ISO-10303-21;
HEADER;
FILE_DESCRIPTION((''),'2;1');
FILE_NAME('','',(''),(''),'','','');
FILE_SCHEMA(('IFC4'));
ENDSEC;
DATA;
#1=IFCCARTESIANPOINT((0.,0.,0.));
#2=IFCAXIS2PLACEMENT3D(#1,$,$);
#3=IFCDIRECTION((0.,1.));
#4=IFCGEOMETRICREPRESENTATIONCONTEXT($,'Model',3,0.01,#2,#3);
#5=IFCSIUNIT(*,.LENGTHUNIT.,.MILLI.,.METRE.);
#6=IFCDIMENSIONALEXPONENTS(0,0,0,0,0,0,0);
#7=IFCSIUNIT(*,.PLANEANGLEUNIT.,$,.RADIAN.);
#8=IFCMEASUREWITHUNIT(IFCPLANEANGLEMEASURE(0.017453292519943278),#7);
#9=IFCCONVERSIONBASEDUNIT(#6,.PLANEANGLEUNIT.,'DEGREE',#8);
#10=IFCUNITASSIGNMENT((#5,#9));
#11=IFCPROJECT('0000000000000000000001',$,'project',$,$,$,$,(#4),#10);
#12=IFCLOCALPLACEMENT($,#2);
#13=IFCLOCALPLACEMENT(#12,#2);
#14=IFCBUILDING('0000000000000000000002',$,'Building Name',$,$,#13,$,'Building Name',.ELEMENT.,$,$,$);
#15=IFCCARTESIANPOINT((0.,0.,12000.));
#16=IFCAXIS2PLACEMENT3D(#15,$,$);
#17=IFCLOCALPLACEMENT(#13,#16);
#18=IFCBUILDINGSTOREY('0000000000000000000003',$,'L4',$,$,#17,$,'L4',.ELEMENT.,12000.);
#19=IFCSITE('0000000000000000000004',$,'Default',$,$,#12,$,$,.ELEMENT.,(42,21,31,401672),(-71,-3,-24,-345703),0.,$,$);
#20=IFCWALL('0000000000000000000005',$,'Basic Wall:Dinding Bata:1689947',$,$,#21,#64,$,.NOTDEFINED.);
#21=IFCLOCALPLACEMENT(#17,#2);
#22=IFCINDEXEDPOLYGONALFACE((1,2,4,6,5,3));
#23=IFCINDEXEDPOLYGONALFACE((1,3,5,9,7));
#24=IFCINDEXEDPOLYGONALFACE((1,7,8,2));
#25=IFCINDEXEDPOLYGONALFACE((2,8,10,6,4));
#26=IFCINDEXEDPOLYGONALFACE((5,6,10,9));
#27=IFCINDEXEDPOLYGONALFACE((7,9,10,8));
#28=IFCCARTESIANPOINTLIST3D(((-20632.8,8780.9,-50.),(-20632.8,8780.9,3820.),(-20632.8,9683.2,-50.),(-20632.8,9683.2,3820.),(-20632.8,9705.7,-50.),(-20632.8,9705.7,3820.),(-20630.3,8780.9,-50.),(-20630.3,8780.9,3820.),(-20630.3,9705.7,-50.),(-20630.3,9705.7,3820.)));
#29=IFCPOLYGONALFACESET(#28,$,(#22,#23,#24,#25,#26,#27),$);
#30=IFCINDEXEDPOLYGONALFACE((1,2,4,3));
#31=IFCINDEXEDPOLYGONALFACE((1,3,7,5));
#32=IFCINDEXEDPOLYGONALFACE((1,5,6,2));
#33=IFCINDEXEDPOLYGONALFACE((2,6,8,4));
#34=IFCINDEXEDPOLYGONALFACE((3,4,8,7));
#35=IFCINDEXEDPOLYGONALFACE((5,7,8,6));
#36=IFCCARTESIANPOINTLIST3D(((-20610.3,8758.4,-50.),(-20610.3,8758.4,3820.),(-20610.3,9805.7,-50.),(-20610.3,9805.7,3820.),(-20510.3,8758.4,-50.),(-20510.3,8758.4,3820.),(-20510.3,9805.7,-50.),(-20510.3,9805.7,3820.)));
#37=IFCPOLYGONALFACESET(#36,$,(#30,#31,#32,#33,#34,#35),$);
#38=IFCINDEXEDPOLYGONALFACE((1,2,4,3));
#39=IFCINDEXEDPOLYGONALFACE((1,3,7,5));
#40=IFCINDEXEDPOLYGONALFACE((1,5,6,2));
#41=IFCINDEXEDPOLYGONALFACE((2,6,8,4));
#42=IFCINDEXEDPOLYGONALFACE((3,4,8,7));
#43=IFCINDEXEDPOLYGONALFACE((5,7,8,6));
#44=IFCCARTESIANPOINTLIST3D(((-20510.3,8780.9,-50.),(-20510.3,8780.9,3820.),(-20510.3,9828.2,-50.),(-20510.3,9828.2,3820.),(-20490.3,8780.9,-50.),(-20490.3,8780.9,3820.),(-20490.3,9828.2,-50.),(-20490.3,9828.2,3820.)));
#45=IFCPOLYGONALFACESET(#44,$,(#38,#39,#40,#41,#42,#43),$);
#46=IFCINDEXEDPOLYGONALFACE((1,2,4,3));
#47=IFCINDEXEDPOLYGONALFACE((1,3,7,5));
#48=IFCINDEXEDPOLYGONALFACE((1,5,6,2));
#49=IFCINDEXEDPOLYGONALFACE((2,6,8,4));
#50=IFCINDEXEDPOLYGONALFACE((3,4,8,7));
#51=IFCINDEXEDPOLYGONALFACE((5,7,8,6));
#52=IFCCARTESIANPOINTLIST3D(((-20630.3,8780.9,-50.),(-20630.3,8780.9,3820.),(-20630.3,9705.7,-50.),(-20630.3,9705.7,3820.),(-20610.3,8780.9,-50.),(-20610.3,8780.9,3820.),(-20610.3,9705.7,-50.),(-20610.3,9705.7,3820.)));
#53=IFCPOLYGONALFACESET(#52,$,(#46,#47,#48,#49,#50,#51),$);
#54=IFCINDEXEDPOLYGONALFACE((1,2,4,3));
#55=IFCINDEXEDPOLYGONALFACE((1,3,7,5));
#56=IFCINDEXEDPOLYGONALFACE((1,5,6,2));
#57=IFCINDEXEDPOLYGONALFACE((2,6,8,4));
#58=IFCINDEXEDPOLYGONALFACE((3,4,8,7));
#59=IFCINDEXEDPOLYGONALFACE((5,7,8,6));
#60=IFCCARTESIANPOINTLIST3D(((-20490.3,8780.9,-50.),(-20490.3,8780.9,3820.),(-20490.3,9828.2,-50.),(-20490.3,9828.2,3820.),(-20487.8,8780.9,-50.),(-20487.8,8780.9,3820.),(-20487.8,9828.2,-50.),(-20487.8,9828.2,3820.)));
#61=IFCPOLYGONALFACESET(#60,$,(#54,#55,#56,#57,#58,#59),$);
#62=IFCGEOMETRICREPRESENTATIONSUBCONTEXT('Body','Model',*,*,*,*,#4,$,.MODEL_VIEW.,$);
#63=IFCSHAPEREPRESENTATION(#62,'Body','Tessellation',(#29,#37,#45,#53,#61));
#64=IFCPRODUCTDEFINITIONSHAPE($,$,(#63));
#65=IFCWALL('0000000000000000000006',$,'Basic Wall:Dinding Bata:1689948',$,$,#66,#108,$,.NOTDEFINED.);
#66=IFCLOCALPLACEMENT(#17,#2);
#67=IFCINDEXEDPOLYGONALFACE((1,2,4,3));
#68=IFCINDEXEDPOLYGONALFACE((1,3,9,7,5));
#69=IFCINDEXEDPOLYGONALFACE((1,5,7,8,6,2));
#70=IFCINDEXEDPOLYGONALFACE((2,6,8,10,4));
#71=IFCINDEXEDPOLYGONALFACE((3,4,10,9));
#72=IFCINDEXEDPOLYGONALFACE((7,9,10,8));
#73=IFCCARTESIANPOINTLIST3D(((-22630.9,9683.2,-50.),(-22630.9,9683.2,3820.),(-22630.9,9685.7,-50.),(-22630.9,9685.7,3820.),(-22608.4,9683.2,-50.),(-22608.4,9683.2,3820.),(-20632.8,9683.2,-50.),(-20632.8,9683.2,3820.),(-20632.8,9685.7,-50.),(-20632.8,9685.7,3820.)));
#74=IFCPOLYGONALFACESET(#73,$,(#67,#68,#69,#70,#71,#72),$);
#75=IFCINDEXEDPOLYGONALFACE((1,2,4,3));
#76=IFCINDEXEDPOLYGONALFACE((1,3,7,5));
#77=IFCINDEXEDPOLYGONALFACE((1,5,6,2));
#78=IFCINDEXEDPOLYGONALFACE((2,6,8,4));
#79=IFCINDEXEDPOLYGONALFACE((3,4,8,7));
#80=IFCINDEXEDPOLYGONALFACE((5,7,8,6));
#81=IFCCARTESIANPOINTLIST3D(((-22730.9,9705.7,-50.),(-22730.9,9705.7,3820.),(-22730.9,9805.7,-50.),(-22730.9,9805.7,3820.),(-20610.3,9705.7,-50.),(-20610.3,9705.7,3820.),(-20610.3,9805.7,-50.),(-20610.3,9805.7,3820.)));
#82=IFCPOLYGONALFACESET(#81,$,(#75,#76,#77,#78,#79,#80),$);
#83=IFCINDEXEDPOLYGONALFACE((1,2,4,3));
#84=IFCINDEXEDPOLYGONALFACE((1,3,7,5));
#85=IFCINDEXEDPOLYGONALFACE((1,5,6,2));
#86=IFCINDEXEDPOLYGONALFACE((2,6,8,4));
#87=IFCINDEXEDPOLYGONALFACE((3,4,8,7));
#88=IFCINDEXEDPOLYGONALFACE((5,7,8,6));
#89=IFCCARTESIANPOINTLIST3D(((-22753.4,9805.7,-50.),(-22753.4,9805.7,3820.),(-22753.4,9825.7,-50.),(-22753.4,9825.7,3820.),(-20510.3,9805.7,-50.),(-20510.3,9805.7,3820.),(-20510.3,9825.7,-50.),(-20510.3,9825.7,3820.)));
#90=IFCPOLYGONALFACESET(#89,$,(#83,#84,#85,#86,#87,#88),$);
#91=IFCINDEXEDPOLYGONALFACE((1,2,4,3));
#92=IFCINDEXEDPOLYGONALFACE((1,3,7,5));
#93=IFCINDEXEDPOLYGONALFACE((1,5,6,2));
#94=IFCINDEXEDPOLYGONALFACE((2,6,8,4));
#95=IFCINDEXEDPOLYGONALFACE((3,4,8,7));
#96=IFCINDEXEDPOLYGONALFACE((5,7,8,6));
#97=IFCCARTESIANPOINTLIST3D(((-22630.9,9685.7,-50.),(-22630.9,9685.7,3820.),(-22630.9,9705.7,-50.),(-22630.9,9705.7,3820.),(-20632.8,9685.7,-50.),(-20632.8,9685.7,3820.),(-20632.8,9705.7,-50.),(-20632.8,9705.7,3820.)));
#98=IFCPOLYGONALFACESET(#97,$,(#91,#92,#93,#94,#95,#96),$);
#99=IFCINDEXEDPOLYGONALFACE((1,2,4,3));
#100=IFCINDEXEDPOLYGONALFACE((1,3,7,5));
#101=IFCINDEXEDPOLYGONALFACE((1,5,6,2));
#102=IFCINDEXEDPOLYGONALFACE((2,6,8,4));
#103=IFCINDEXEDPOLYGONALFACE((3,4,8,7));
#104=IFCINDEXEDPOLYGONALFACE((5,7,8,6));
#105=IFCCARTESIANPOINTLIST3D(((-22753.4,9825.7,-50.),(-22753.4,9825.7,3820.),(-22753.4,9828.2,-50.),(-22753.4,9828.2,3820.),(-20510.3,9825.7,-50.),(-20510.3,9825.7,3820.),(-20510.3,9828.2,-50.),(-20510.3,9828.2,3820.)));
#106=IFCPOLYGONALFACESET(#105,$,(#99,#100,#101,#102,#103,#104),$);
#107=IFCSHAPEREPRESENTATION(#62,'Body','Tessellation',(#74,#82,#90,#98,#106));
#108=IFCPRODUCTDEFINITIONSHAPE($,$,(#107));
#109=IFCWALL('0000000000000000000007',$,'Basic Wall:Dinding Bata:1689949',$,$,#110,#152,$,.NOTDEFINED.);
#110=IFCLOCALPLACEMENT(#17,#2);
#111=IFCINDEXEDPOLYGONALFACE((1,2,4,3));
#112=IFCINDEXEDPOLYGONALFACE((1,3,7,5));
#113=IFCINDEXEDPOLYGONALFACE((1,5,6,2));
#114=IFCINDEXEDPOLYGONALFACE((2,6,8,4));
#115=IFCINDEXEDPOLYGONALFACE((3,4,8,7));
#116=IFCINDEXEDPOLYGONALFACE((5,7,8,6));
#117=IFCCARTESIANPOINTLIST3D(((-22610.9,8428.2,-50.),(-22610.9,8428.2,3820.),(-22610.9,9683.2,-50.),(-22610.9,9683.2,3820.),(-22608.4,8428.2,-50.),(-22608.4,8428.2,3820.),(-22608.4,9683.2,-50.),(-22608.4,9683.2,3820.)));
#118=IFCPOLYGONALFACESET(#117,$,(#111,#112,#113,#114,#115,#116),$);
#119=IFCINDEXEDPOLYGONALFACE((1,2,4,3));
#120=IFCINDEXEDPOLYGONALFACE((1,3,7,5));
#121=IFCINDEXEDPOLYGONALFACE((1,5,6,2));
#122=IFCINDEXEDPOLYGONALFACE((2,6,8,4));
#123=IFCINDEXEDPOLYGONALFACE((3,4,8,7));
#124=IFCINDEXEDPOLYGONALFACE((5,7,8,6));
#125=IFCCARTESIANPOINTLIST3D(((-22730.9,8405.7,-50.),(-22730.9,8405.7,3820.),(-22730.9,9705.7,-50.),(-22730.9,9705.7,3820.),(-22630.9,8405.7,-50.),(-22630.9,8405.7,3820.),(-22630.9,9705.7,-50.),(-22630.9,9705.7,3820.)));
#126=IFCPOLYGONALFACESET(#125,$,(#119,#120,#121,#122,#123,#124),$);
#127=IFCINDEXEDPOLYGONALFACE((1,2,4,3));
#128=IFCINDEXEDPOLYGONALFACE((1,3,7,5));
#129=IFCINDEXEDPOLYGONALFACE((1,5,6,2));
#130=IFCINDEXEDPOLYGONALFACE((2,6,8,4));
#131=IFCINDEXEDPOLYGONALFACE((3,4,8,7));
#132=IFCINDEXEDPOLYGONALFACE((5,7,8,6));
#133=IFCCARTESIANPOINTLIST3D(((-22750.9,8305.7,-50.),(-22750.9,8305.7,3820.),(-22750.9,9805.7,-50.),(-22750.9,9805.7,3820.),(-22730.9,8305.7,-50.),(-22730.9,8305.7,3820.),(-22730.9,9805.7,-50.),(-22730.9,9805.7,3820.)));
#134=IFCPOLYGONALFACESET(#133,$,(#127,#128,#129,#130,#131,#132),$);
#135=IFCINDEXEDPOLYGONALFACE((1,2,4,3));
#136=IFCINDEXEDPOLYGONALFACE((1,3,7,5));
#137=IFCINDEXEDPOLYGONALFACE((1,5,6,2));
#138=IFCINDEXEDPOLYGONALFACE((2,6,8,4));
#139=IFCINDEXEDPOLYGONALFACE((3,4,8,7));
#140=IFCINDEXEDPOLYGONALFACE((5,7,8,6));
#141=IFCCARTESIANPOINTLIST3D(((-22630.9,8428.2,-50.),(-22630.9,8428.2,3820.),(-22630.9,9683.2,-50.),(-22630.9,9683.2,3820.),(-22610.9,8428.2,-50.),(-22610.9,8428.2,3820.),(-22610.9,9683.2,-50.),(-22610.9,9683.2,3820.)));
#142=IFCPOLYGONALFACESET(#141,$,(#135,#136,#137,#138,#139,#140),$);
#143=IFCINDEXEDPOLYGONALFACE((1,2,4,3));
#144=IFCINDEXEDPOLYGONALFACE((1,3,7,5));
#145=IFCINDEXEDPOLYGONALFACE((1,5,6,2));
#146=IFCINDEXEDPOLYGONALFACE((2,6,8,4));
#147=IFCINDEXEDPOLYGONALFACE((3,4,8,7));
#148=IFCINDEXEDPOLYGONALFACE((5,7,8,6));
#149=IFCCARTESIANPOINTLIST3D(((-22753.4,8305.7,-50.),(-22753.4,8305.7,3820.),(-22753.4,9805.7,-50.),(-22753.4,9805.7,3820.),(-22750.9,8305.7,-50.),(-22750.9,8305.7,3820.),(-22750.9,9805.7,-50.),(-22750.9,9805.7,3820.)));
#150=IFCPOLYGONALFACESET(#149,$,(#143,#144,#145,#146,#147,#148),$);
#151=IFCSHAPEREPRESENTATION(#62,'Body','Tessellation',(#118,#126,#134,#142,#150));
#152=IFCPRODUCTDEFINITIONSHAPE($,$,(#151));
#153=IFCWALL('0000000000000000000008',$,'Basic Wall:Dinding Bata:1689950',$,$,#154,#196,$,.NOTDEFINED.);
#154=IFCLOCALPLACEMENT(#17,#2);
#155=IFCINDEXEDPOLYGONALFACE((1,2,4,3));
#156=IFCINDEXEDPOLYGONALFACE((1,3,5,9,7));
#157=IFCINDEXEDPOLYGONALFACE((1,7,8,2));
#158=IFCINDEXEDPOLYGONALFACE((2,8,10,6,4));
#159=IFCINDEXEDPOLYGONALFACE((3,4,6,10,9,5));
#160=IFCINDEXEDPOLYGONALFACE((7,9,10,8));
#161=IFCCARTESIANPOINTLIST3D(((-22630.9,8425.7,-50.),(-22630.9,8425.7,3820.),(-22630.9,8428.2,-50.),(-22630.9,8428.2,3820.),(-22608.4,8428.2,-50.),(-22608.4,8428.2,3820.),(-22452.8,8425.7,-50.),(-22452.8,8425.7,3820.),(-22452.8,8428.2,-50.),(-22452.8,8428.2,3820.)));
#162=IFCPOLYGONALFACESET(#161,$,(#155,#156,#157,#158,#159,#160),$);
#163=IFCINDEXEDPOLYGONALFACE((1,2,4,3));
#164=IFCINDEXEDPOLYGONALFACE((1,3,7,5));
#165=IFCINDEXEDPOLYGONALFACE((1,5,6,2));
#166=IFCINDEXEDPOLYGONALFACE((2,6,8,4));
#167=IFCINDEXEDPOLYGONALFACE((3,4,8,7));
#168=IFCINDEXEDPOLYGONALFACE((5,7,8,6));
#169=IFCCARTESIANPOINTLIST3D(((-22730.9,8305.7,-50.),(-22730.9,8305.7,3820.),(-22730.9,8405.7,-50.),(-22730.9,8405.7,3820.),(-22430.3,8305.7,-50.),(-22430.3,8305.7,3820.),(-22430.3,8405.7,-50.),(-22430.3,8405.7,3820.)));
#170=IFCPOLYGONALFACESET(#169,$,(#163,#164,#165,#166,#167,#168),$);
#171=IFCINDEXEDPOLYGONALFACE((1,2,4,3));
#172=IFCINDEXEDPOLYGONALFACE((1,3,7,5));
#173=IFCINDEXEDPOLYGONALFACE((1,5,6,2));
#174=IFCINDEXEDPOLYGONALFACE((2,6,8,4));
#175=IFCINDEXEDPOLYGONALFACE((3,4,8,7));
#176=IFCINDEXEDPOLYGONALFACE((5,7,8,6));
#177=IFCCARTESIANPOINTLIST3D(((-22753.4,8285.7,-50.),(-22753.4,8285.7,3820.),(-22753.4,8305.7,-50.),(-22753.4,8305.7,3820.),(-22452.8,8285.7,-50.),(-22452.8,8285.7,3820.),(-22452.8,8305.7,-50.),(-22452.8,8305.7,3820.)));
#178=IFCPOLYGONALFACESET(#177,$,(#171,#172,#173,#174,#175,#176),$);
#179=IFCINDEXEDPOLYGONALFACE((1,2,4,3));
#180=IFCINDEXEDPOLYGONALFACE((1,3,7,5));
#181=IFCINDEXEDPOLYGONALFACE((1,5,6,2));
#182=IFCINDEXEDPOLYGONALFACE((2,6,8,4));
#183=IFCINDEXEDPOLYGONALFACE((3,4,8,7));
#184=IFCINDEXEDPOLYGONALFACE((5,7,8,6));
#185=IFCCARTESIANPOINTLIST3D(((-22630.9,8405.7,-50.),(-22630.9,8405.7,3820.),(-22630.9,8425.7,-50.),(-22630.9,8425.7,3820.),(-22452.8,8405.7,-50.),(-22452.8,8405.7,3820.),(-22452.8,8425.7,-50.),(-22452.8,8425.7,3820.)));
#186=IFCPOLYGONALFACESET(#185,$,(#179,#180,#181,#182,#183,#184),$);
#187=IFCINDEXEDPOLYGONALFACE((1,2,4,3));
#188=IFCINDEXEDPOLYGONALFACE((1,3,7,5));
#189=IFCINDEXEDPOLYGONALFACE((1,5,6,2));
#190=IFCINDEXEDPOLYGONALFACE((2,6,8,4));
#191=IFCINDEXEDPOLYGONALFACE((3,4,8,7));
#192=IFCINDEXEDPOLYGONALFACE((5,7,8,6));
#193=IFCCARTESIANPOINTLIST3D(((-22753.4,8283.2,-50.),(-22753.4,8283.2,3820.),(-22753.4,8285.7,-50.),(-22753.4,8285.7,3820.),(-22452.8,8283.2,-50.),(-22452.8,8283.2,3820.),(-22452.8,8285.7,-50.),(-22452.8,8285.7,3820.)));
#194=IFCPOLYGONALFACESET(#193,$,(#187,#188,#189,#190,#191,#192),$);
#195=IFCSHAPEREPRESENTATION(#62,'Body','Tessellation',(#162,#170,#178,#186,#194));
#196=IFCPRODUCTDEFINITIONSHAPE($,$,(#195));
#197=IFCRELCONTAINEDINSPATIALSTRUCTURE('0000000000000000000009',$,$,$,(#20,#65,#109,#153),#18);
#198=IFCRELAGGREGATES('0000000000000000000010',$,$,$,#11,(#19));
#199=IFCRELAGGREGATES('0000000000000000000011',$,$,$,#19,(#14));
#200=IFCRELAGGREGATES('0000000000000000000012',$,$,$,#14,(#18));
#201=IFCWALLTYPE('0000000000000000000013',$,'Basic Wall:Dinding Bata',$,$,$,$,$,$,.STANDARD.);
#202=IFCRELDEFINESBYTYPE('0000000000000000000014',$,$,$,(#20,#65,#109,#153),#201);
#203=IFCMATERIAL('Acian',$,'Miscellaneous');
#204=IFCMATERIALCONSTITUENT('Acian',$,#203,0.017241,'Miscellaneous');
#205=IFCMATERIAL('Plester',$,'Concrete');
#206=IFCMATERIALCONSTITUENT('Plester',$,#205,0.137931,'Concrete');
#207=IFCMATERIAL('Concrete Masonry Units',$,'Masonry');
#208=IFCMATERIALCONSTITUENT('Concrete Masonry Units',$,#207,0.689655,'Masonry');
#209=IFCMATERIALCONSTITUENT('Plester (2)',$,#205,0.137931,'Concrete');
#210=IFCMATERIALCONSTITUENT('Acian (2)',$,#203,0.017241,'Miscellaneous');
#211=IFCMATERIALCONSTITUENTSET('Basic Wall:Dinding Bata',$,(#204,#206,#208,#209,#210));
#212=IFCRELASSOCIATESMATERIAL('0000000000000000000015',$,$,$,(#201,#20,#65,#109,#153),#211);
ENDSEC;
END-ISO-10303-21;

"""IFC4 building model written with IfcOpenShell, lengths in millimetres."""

from ifc_helpers import new_model, entity, si_unit, converted_unit, direction, frame, origin, place, context, subcontext, project, spatial, indexed_curve, outline, extrude, material, constituent, constituent_set, type_object, element, save


model = new_model("IFC4")

# Units and contexts
model_context = context("Model", 3, precision=0.01, world=origin(), true_north=direction((0.0, 1.0)))
body_context = subcontext(model_context, "Body", "Model", "MODEL_VIEW")
ifc_project = project(units=[si_unit("LENGTHUNIT", "METRE", prefix="MILLI"), converted_unit("PLANEANGLEUNIT", "DEGREE", entity("IfcPlaneAngleMeasure", 0.017453292519943278), si_unit("PLANEANGLEUNIT", "RADIAN"), dimensions=[0, 0, 0, 0, 0, 0, 0])], contexts=[model_context])

# Site, building, storey
site_placement = place(None, origin())
site = spatial("IfcSite", under=ifc_project, at=site_placement, Name="Default", CompositionType="ELEMENT", RefLatitude=(42, 21, 31, 401672), RefLongitude=(-71, -3, -24, -345703), RefElevation=0.0)
building_placement = place(site_placement, origin())
building = spatial("IfcBuilding", under=site, at=building_placement, Name="Building Name", LongName="Building Name", CompositionType="ELEMENT")
storey_placement = place(building_placement, frame((0.0, 0.0, 12000.0)))
storey = spatial("IfcBuildingStorey", under=building, at=storey_placement, Name="L4", LongName="L4", CompositionType="ELEMENT", Elevation=12000.0)

# Walls
ifc_material_1 = material(Name="Acian", Category="Miscellaneous")
ifc_constituent_1 = constituent(ifc_material_1, Name="Acian", Category="Miscellaneous", fraction=0.017241)
ifc_material_2 = material(Name="Plester", Category="Concrete")
ifc_constituent_2 = constituent(ifc_material_2, Name="Plester", Category="Concrete", fraction=0.137931)
ifc_material_3 = material(Name="Concrete Masonry Units", Category="Masonry")
ifc_constituent_3 = constituent(ifc_material_3, Name="Concrete Masonry Units", Category="Masonry", fraction=0.689655)
ifc_constituent_4 = constituent(ifc_material_2, Name="Plester (2)", Category="Concrete", fraction=0.137931)
ifc_constituent_5 = constituent(ifc_material_1, Name="Acian (2)", Category="Miscellaneous", fraction=0.017241)
ifc_constituent_set = constituent_set(constituents=[ifc_constituent_1, ifc_constituent_2, ifc_constituent_3, ifc_constituent_4, ifc_constituent_5], Name="Basic Wall:Dinding Bata")
wall_type = type_object("IfcWallType", Name="Basic Wall:Dinding Bata", PredefinedType="STANDARD", material=ifc_constituent_set)
wall_1_placement = place(storey_placement, frame((-20560.3, 8780.9, -50.0), z_axis=(0.0, 0.0, 1.0), x_axis=(0.0, 1.0, 0.0)))
element("IfcWall", 1, at=wall_1_placement, inside=storey, type_object=wall_type, material=ifc_constituent_set, Name="Basic Wall:Dinding Bata:1689947", PredefinedType="NOTDEFINED", context=body_context, shape_type="SweptSolid", body=[
    extrude(outline(indexed_curve([(-351.9, -1.0), (550.4, -1.0), (550.4, 1.5), (-374.4, 1.5), (-374.4, -1.0), (-351.9, -1.0)], self_intersect=False)), frame((550.4, 71.5, 0.0), z_axis=(0.0, 0.0, 1.0), x_axis=(-1.0, 0.0, 0.0)), (0.0, 0.0, 1.0), 3870.0),
    extrude(outline(indexed_curve([(-523.7, -50.0), (523.7, -50.0), (523.7, 50.0), (-523.7, 50.0), (-523.7, -50.0)], self_intersect=False)), frame((501.2, 0.0, 0.0)), (0.0, 0.0, 1.0), 3870.0),
    extrude(outline(indexed_curve([(-523.7, -10.0), (523.7, -10.0), (523.7, 10.0), (-523.7, 10.0), (-523.7, -10.0)], self_intersect=False)), frame((523.7, -60.0, 0.0)), (0.0, 0.0, 1.0), 3870.0),
    extrude(outline(indexed_curve([(-462.4, -10.0), (462.4, -10.0), (462.4, 10.0), (-462.4, 10.0), (-462.4, -10.0)], self_intersect=False)), frame((462.4, 60.0, 0.0)), (0.0, 0.0, 1.0), 3870.0),
    extrude(outline(indexed_curve([(-1.2, -523.7), (1.2, -523.7), (1.2, 523.7), (-1.2, 523.7), (-1.2, -523.7)], self_intersect=False)), frame((523.7, -71.3, 0.0), z_axis=(0.0, 0.0, 1.0), x_axis=(0.0, 1.0, 0.0)), (0.0, 0.0, 1.0), 3870.0),
])
wall_2_placement = place(storey_placement, frame((-20632.8, 9755.7, -50.0), z_axis=(0.0, 0.0, 1.0), x_axis=(-1.0, 0.0, 0.0)))
element("IfcWall", 2, at=wall_2_placement, inside=storey, type_object=wall_type, material=ifc_constituent_set, Name="Basic Wall:Dinding Bata:1689948", PredefinedType="NOTDEFINED", context=body_context, shape_type="SweptSolid", body=[
    extrude(outline(indexed_curve([(-781.2, -1.0), (1194.4, -1.0), (1194.4, 1.5), (-803.7, 1.5), (-803.7, -1.0), (-781.2, -1.0)], self_intersect=False)), frame((1194.4, 71.5, 0.0), z_axis=(0.0, 0.0, 1.0), x_axis=(-1.0, 0.0, 0.0)), (0.0, 0.0, 1.0), 3870.0),
    extrude(outline(indexed_curve([(-1060.3, -50.0), (1060.3, -50.0), (1060.3, 50.0), (-1060.3, 50.0), (-1060.3, -50.0)], self_intersect=False)), frame((1037.8, 0.0, 0.0)), (0.0, 0.0, 1.0), 3870.0),
    extrude(outline(indexed_curve([(-1121.5, -10.0), (1121.5, -10.0), (1121.5, 10.0), (-1121.5, 10.0), (-1121.5, -10.0)], self_intersect=False)), frame((999.0, -60.0, 0.0)), (0.0, 0.0, 1.0), 3870.0),
    extrude(outline(indexed_curve([(-999.0, -10.0), (999.0, -10.0), (999.0, 10.0), (-999.0, 10.0), (-999.0, -10.0)], self_intersect=False)), frame((999.0, 60.0, 0.0)), (0.0, 0.0, 1.0), 3870.0),
    extrude(outline(indexed_curve([(-1.3, -1121.5), (1.2, -1121.5), (1.3, 1121.5), (-1.2, 1121.5), (-1.3, -1121.5)], self_intersect=False)), frame((999.0, -71.2, 0.0), z_axis=(0.0, 0.0, 1.0), x_axis=(0.0, 1.0, 0.0)), (0.0, 0.0, 1.0), 3870.0),
])
wall_3_placement = place(storey_placement, frame((-22680.9, 9683.2, -50.0), z_axis=(0.0, 0.0, 1.0), x_axis=(0.0, -1.0, 0.0)))
element("IfcWall", 3, at=wall_3_placement, inside=storey, type_object=wall_type, material=ifc_constituent_set, Name="Basic Wall:Dinding Bata:1689949", PredefinedType="NOTDEFINED", context=body_context, shape_type="SweptSolid", body=[
    extrude(outline(indexed_curve([(-1.2, -627.5), (1.2, -627.5), (1.3, 627.5), (-1.2, 627.5), (-1.2, -627.5)], self_intersect=False)), frame((627.5, 71.3, 0.0), z_axis=(0.0, 0.0, 1.0), x_axis=(0.0, -1.0, 0.0)), (0.0, 0.0, 1.0), 3870.0),
    extrude(outline(indexed_curve([(-650.0, -50.0), (650.0, -50.0), (650.0, 50.0), (-650.0, 50.0), (-650.0, -50.0)], self_intersect=False)), frame((627.5, 0.0, 0.0)), (0.0, 0.0, 1.0), 3870.0),
    extrude(outline(indexed_curve([(-750.0, -10.0), (750.0, -10.0), (750.0, 10.0), (-750.0, 10.0), (-750.0, -10.0)], self_intersect=False)), frame((627.5, -60.0, 0.0)), (0.0, 0.0, 1.0), 3870.0),
    extrude(outline(indexed_curve([(-627.5, -10.0), (627.5, -10.0), (627.5, 10.0), (-627.5, 10.0), (-627.5, -10.0)], self_intersect=False)), frame((627.5, 60.0, 0.0)), (0.0, 0.0, 1.0), 3870.0),
    extrude(outline(indexed_curve([(-1.3, -750.0), (1.2, -750.0), (1.2, 750.0), (-1.2, 750.0), (-1.3, -750.0)], self_intersect=False)), frame((627.5, -71.2, 0.0), z_axis=(0.0, 0.0, 1.0), x_axis=(0.0, 1.0, 0.0)), (0.0, 0.0, 1.0), 3870.0),
])
wall_4_placement = place(storey_placement, frame((-22753.4, 8355.7, -50.0)))
element("IfcWall", 4, at=wall_4_placement, inside=storey, type_object=wall_type, material=ifc_constituent_set, Name="Basic Wall:Dinding Bata:1689950", PredefinedType="NOTDEFINED", context=body_context, shape_type="SweptSolid", body=[
    extrude(outline(indexed_curve([(53.2, -1.0), (75.7, -1.0), (75.7, 1.5), (-102.4, 1.5), (-102.4, -1.0), (53.2, -1.0)], self_intersect=False)), frame((198.2, 71.5, 0.0), z_axis=(0.0, 0.0, 1.0), x_axis=(-1.0, 0.0, 0.0)), (0.0, 0.0, 1.0), 3870.0),
    extrude(outline(indexed_curve([(-150.3, -50.0), (150.3, -50.0), (150.3, 50.0), (-150.3, 50.0), (-150.3, -50.0)], self_intersect=False)), frame((172.8, 0.0, 0.0)), (0.0, 0.0, 1.0), 3870.0),
    extrude(outline(indexed_curve([(-150.3, -10.0), (150.3, -10.0), (150.3, 10.0), (-150.3, 10.0), (-150.3, -10.0)], self_intersect=False)), frame((150.3, -60.0, 0.0)), (0.0, 0.0, 1.0), 3870.0),
    extrude(outline(indexed_curve([(-89.0, -10.0), (89.0, -10.0), (89.0, 10.0), (-89.0, 10.0), (-89.0, -10.0)], self_intersect=False)), frame((211.5, 60.0, 0.0)), (0.0, 0.0, 1.0), 3870.0),
    extrude(outline(indexed_curve([(-1.2, -150.3), (1.2, -150.3), (1.3, 150.3), (-1.2, 150.3), (-1.2, -150.3)], self_intersect=False)), frame((150.3, -71.3, 0.0), z_axis=(0.0, 0.0, 1.0), x_axis=(0.0, 1.0, 0.0)), (0.0, 0.0, 1.0), 3870.0),
])

save(model, "model.ifc")
